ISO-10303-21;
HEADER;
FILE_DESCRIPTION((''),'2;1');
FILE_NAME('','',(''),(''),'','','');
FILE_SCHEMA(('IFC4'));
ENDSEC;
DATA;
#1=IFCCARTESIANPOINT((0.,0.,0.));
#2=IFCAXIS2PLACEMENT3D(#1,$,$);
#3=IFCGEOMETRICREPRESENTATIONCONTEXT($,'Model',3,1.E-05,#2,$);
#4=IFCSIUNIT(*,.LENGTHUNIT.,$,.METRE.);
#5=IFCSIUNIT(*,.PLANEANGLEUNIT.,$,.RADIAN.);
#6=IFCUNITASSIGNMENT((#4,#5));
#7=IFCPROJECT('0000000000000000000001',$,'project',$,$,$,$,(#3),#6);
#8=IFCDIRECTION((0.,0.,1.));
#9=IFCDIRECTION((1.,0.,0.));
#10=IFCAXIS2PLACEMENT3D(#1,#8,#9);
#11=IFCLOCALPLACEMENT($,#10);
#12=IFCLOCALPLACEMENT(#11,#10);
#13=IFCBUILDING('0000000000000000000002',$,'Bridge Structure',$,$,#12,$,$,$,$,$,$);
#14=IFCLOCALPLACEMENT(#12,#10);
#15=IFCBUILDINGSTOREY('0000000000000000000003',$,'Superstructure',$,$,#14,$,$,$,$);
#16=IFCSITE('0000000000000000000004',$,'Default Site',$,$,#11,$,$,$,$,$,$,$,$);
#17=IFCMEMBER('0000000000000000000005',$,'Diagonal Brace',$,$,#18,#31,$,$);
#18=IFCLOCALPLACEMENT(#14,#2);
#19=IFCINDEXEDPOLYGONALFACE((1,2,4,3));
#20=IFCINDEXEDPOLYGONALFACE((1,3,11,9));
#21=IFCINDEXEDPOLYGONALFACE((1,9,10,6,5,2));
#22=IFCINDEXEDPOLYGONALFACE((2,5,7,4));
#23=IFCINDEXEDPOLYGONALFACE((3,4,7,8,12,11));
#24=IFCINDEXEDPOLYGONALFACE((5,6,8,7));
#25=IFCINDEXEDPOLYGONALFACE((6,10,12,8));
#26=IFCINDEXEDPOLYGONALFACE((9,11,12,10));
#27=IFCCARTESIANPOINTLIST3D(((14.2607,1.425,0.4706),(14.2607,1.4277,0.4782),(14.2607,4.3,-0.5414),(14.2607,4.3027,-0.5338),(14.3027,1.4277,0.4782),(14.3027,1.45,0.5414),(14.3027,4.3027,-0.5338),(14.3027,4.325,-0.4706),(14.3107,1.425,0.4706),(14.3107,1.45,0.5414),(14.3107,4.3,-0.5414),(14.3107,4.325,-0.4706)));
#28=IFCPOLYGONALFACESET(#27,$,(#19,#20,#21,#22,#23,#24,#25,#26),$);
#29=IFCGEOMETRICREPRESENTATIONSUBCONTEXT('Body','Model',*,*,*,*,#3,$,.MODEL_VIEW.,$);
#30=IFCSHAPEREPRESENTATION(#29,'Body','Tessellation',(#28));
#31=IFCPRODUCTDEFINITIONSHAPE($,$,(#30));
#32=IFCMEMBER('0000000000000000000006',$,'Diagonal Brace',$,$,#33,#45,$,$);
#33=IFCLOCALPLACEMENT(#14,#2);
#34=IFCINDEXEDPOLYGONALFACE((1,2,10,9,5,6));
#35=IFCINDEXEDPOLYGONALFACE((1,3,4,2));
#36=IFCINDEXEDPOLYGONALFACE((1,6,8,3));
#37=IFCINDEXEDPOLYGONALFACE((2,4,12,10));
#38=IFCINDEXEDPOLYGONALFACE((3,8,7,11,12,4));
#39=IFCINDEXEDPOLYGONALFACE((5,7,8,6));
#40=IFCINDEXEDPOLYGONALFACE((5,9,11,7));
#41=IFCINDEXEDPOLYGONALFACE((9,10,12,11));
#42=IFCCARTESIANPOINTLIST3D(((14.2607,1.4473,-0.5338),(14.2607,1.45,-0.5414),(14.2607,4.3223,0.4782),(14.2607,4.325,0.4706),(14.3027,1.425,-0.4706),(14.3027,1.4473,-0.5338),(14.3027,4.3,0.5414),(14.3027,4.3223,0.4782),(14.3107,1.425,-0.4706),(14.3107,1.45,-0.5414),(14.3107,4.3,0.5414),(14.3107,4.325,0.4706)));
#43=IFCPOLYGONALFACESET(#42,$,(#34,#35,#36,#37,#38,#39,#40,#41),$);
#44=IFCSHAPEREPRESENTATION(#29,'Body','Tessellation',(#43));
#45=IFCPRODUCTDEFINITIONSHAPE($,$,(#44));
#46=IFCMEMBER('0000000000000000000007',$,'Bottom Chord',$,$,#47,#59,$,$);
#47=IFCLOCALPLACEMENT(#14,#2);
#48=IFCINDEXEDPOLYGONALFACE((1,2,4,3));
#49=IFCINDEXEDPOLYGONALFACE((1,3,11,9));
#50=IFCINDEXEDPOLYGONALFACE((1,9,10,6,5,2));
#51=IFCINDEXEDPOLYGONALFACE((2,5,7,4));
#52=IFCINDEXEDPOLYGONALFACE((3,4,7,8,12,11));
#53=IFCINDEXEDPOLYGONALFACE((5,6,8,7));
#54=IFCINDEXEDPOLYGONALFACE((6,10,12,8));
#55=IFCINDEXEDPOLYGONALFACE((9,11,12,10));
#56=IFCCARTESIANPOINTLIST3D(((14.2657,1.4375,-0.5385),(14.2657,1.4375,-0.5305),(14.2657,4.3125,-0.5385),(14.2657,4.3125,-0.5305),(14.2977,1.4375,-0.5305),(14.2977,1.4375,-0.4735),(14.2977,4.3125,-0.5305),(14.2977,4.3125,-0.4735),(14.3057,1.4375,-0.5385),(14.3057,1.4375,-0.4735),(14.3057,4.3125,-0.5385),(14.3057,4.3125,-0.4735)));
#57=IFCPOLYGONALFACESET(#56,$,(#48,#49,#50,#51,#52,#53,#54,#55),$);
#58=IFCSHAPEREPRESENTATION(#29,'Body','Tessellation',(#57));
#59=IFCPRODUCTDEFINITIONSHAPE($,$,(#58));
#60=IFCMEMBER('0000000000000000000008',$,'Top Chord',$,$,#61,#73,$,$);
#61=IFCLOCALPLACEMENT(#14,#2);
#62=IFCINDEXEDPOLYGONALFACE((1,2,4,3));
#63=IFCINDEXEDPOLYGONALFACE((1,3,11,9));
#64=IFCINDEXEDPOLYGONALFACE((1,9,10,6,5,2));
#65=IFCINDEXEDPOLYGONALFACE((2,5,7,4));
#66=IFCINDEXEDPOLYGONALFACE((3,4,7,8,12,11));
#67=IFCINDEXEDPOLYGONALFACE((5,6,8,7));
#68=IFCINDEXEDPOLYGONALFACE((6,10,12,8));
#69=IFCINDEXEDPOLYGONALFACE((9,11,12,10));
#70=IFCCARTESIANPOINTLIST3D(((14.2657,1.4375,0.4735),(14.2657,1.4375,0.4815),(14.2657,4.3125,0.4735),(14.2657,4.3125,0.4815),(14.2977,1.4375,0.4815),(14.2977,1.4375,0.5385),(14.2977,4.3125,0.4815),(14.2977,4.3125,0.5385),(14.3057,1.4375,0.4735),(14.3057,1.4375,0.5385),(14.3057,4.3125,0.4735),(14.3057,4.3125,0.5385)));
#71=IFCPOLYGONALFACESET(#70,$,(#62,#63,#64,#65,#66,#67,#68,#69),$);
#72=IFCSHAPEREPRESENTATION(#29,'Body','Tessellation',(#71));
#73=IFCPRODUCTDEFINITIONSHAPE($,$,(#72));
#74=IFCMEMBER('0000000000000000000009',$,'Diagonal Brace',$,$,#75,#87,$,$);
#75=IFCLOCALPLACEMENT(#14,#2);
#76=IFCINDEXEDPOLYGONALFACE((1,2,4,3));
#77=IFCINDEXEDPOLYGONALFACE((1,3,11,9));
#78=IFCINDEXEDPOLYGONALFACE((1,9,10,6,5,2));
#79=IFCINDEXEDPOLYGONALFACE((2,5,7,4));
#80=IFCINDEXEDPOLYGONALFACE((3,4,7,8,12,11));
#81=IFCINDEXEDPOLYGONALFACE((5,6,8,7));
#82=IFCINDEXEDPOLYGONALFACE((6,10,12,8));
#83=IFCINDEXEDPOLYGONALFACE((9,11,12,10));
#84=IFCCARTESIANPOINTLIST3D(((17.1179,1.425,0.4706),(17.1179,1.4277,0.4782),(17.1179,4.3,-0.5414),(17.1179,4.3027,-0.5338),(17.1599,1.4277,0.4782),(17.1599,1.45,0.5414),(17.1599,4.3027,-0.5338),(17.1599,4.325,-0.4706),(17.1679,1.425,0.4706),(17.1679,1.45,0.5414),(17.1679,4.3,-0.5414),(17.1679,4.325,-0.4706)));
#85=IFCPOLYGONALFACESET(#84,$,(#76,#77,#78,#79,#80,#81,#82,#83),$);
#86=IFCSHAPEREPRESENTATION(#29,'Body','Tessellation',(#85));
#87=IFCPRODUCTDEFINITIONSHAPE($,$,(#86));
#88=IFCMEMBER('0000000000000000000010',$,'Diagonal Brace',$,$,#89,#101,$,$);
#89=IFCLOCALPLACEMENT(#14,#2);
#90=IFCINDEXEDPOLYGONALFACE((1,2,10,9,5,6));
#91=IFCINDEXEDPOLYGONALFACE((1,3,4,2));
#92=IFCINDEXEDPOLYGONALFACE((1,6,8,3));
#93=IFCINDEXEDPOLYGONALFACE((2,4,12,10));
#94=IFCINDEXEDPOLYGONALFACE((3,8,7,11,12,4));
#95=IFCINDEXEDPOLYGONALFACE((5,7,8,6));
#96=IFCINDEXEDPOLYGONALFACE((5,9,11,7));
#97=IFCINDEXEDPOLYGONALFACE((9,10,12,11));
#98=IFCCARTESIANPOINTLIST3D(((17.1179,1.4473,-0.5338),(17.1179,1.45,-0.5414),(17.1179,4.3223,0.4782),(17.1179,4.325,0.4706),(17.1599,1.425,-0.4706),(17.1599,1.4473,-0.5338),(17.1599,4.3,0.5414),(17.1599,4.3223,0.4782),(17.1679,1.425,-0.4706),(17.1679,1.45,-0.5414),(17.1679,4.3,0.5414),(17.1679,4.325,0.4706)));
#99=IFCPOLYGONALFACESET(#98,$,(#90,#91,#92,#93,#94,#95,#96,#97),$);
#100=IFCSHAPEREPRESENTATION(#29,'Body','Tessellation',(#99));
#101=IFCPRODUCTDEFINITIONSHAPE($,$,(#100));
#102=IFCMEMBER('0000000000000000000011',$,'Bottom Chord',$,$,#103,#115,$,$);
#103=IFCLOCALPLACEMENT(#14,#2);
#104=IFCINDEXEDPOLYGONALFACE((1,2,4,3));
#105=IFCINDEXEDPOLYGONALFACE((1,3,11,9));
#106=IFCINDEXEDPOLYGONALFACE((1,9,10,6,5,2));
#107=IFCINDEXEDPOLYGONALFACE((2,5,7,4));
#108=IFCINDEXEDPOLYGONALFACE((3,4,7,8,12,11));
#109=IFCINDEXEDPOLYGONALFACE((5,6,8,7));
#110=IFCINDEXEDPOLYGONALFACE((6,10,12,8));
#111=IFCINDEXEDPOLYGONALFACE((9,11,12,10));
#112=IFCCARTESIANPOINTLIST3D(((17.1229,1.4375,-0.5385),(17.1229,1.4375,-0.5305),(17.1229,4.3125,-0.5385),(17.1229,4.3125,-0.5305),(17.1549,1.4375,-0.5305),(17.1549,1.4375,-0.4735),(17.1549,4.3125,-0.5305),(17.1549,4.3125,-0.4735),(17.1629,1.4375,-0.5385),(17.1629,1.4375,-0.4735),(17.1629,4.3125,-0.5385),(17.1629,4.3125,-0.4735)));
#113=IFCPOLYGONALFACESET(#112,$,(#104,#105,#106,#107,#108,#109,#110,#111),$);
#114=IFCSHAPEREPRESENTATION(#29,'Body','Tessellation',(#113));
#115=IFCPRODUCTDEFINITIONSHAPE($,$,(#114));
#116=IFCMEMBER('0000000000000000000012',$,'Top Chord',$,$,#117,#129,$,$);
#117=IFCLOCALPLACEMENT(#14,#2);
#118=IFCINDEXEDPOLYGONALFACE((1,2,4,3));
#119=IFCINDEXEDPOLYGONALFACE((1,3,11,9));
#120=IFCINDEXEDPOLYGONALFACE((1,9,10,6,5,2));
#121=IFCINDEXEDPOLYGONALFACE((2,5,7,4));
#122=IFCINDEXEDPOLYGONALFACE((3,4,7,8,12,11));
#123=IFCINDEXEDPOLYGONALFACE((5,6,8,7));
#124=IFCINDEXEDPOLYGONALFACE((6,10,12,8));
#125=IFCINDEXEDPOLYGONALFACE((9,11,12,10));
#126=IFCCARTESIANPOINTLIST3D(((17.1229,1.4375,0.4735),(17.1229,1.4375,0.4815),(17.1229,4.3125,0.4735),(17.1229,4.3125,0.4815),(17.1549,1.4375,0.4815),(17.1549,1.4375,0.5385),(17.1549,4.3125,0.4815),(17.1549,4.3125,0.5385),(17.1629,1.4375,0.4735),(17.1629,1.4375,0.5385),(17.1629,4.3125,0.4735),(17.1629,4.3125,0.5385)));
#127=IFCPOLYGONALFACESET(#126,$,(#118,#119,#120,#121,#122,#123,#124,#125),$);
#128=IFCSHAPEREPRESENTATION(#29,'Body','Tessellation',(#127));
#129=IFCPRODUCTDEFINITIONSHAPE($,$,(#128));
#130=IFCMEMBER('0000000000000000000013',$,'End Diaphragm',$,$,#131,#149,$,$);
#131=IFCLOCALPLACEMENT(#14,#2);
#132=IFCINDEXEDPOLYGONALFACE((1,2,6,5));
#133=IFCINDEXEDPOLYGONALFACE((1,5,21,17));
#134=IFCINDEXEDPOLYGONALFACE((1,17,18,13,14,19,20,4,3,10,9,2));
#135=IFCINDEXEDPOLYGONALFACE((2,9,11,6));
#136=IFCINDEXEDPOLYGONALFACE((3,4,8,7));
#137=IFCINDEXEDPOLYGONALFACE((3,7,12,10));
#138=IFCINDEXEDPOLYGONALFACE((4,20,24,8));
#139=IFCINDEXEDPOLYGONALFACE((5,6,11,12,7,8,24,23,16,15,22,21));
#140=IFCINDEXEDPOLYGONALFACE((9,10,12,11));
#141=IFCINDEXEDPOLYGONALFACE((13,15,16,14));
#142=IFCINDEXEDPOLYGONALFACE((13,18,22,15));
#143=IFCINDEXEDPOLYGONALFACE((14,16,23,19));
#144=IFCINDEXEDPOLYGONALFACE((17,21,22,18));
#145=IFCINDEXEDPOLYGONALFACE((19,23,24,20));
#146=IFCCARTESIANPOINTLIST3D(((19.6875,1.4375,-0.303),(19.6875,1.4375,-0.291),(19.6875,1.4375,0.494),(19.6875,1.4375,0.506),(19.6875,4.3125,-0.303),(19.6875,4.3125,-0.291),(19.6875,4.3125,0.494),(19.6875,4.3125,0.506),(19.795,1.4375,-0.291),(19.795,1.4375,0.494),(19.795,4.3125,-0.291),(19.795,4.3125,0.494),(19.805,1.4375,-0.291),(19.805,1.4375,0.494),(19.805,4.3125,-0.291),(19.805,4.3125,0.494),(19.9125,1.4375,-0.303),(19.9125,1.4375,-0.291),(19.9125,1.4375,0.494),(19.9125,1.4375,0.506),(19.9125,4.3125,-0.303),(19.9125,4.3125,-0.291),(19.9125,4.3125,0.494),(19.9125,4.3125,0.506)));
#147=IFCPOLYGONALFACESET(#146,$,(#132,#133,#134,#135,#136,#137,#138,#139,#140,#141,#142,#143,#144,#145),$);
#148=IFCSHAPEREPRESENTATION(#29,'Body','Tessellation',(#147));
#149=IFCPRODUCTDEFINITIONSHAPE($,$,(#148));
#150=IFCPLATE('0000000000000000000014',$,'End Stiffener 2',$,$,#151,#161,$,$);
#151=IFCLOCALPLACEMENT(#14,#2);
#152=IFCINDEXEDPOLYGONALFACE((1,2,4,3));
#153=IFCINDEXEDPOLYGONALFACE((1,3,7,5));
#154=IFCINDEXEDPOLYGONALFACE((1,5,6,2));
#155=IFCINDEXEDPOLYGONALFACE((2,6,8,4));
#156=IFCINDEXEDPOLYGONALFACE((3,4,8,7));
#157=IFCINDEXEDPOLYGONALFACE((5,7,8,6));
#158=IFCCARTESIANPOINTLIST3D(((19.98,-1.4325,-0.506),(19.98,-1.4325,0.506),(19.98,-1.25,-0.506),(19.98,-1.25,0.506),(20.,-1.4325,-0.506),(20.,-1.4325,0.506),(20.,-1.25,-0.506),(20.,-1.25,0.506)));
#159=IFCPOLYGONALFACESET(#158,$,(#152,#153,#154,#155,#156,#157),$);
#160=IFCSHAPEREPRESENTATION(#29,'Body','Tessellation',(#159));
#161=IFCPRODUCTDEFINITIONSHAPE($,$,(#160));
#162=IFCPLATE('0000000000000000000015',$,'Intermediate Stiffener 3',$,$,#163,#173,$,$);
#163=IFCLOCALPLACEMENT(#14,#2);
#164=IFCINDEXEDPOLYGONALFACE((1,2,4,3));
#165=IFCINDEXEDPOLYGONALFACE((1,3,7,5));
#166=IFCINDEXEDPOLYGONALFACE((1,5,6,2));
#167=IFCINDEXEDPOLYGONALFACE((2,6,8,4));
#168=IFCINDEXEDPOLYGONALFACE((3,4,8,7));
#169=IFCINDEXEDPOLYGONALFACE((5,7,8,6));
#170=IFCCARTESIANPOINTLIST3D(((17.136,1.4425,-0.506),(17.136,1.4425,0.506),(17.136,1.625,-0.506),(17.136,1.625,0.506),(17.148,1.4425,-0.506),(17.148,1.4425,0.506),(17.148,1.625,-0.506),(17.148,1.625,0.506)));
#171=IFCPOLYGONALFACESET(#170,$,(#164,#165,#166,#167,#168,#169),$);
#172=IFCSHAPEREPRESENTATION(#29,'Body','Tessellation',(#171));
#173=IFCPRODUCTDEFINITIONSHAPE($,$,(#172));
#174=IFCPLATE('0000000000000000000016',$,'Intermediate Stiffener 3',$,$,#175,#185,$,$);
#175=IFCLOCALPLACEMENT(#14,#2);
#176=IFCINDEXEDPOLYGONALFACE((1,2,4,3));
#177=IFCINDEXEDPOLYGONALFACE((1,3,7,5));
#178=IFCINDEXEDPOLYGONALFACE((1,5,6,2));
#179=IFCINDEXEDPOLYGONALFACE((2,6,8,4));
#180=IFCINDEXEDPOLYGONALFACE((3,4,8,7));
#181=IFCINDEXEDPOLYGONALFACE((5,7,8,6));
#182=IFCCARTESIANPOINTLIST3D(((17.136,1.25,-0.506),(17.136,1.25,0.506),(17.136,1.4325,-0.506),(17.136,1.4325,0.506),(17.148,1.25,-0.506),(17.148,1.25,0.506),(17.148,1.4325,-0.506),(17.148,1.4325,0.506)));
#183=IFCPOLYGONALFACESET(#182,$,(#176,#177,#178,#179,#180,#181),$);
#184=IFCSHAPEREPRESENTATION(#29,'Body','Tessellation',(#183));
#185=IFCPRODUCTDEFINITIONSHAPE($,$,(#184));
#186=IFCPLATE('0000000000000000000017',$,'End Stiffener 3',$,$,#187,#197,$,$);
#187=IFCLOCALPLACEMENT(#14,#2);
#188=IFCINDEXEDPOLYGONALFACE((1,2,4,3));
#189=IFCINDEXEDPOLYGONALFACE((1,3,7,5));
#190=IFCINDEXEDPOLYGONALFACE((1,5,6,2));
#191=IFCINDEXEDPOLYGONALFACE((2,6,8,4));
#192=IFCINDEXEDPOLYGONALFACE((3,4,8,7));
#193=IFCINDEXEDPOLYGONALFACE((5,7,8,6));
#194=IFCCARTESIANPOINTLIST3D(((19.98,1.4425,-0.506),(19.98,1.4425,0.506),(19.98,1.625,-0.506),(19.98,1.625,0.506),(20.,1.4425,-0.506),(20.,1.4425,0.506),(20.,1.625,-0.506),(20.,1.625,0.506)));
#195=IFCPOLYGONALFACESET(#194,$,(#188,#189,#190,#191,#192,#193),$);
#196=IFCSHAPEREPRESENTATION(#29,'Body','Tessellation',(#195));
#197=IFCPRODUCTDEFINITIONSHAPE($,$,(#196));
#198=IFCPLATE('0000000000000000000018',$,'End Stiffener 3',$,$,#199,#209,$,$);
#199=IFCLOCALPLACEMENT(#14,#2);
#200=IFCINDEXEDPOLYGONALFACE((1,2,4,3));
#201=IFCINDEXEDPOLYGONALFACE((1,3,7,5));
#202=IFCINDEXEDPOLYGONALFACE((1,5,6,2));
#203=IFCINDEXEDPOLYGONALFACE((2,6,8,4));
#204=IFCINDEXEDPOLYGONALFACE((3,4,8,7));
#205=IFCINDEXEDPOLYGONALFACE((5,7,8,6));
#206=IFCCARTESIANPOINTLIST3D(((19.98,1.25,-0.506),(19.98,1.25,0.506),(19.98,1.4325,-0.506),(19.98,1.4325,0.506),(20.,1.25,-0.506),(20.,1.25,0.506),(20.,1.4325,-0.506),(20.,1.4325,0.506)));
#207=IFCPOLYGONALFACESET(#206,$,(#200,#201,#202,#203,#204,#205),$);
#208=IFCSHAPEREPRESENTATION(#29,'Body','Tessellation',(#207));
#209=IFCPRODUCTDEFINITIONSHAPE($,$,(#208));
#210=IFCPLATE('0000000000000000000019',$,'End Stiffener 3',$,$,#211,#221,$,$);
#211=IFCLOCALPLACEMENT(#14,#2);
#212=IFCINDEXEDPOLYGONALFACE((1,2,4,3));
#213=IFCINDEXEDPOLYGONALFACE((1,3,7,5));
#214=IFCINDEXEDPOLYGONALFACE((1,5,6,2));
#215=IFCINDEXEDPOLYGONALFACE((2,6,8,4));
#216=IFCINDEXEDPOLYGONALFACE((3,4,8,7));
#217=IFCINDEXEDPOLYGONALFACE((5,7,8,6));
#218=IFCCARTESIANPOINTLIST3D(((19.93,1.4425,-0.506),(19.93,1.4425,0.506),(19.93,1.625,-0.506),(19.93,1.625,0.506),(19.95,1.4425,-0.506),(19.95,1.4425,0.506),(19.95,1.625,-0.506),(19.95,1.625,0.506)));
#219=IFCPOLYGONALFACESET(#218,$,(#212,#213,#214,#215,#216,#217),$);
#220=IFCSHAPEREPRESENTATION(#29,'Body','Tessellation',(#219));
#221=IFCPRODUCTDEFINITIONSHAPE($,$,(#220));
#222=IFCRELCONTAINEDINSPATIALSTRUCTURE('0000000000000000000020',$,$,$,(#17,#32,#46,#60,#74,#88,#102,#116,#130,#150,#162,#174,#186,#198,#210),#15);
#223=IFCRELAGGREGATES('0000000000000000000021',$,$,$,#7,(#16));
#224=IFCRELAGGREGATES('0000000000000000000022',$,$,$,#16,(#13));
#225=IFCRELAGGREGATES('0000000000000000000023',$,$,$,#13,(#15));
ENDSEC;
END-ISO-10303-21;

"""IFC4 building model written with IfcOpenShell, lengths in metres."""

from ifc_helpers import new_model, si_unit, frame, origin, origin_with_axes, origin_2d_with_axis, place, context, subcontext, project, spatial, rectangle, i_section, l_section, extrude, element, save


model = new_model("IFC4")

# Units and contexts
model_context = context("Model", 3, precision=1e-05, world=origin())
body_context = subcontext(model_context, "Body", "Model", "MODEL_VIEW")
ifc_project = project(units=[si_unit("LENGTHUNIT", "METRE"), si_unit("PLANEANGLEUNIT", "RADIAN")], contexts=[model_context])

# Site, building, storey
site_placement = place(None, origin_with_axes())
site = spatial("IfcSite", under=ifc_project, at=site_placement, Name="Default Site")
building_placement = place(site_placement, origin_with_axes())
building = spatial("IfcBuilding", under=site, at=building_placement, Name="Bridge Structure")
storey_placement = place(building_placement, origin_with_axes())
storey = spatial("IfcBuildingStorey", under=building, at=storey_placement, Name="Superstructure")

# Members
for number, where, z_axis, x_axis, name in (
    (1, (14.2857, 1.4375, 0.506), (0.0, 0.943269, -0.332031), (-1.0, 0.0, 0.0), "Diagonal Brace"),
    (2, (14.2857, 1.4375, -0.506), (0.0, 0.943269, 0.332031), (-1.0, 0.0, 0.0), "Diagonal Brace"),
):
    element("IfcMember", number, at=place(storey_placement, frame(where, z_axis=z_axis, x_axis=x_axis)), inside=storey, Name=name, context=body_context, shape_type="SweptSolid", body=[
        extrude(l_section(Depth=0.075, Width=0.05, Thickness=0.008, at=origin_2d_with_axis()), origin_with_axes(), (0.0, 0.0, 1.0), 3.0479),
    ])
for number, where, z_axis, x_axis, name in (
    (3, (14.2857, 1.4375, -0.506), (0.0, 1.0, 0.0), (-1.0, 0.0, 0.0), "Bottom Chord"),
    (4, (14.2857, 1.4375, 0.506), (0.0, 1.0, 0.0), (-1.0, 0.0, 0.0), "Top Chord"),
):
    element("IfcMember", number, at=place(storey_placement, frame(where, z_axis=z_axis, x_axis=x_axis)), inside=storey, Name=name, context=body_context, shape_type="SweptSolid", body=[
        extrude(l_section(Depth=0.065, Width=0.04, Thickness=0.008, at=origin_2d_with_axis()), origin_with_axes(), (0.0, 0.0, 1.0), 2.875),
    ])
for number, where, z_axis, x_axis, name in (
    (5, (17.1429, 1.4375, 0.506), (0.0, 0.943269, -0.332031), (-1.0, 0.0, 0.0), "Diagonal Brace"),
    (6, (17.1429, 1.4375, -0.506), (0.0, 0.943269, 0.332031), (-1.0, 0.0, 0.0), "Diagonal Brace"),
):
    element("IfcMember", number, at=place(storey_placement, frame(where, z_axis=z_axis, x_axis=x_axis)), inside=storey, Name=name, context=body_context, shape_type="SweptSolid", body=[
        extrude(l_section(Depth=0.075, Width=0.05, Thickness=0.008, at=origin_2d_with_axis()), origin_with_axes(), (0.0, 0.0, 1.0), 3.0479),
    ])
for number, where, z_axis, x_axis, name in (
    (7, (17.1429, 1.4375, -0.506), (0.0, 1.0, 0.0), (-1.0, 0.0, 0.0), "Bottom Chord"),
    (8, (17.1429, 1.4375, 0.506), (0.0, 1.0, 0.0), (-1.0, 0.0, 0.0), "Top Chord"),
):
    element("IfcMember", number, at=place(storey_placement, frame(where, z_axis=z_axis, x_axis=x_axis)), inside=storey, Name=name, context=body_context, shape_type="SweptSolid", body=[
        extrude(l_section(Depth=0.065, Width=0.04, Thickness=0.008, at=origin_2d_with_axis()), origin_with_axes(), (0.0, 0.0, 1.0), 2.875),
    ])
member_placement = place(storey_placement, frame((19.8, 1.4375, 0.1015), z_axis=(0.0, 1.0, 0.0), x_axis=(-1.0, 0.0, 0.0)))
element("IfcMember", 9, at=member_placement, inside=storey, Name="End Diaphragm", context=body_context, shape_type="SweptSolid", body=[
    extrude(i_section(OverallWidth=0.225, OverallDepth=0.809, WebThickness=0.01, FlangeThickness=0.012, at=origin_2d_with_axis()), origin_with_axes(), (0.0, 0.0, 1.0), 2.875),
])

# Plates
plate_placement = place(storey_placement, frame((19.99, -1.3413, -0.506), z_axis=(0.0, 0.0, 1.0), x_axis=(1.0, 0.0, 0.0)))
element("IfcPlate", 10, at=plate_placement, inside=storey, Name="End Stiffener 2", context=body_context, shape_type="SweptSolid", body=[
    extrude(rectangle(XDim=0.02, YDim=0.1825, at=origin_2d_with_axis()), origin_with_axes(), (0.0, 0.0, 1.0), 1.012),
])
for number, where, z_axis, x_axis, name in (
    (11, (17.142, 1.5337, -0.506), (0.0, 0.0, 1.0), (1.0, 0.0, 0.0), "Intermediate Stiffener 3"),
    (12, (17.142, 1.3413, -0.506), (0.0, 0.0, 1.0), (1.0, 0.0, 0.0), "Intermediate Stiffener 3"),
):
    element("IfcPlate", number, at=place(storey_placement, frame(where, z_axis=z_axis, x_axis=x_axis)), inside=storey, Name=name, context=body_context, shape_type="SweptSolid", body=[
        extrude(rectangle(XDim=0.012, YDim=0.1825, at=origin_2d_with_axis()), origin_with_axes(), (0.0, 0.0, 1.0), 1.012),
    ])
for number, where, z_axis, x_axis, name in (
    (13, (19.99, 1.5337, -0.506), (0.0, 0.0, 1.0), (1.0, 0.0, 0.0), "End Stiffener 3"),
    (14, (19.99, 1.3413, -0.506), (0.0, 0.0, 1.0), (1.0, 0.0, 0.0), "End Stiffener 3"),
    (15, (19.94, 1.5337, -0.506), (0.0, 0.0, 1.0), (1.0, 0.0, 0.0), "End Stiffener 3"),
):
    element("IfcPlate", number, at=place(storey_placement, frame(where, z_axis=z_axis, x_axis=x_axis)), inside=storey, Name=name, context=body_context, shape_type="SweptSolid", body=[
        extrude(rectangle(XDim=0.02, YDim=0.1825, at=origin_2d_with_axis()), origin_with_axes(), (0.0, 0.0, 1.0), 1.012),
    ])

save(model, "model.ifc")
